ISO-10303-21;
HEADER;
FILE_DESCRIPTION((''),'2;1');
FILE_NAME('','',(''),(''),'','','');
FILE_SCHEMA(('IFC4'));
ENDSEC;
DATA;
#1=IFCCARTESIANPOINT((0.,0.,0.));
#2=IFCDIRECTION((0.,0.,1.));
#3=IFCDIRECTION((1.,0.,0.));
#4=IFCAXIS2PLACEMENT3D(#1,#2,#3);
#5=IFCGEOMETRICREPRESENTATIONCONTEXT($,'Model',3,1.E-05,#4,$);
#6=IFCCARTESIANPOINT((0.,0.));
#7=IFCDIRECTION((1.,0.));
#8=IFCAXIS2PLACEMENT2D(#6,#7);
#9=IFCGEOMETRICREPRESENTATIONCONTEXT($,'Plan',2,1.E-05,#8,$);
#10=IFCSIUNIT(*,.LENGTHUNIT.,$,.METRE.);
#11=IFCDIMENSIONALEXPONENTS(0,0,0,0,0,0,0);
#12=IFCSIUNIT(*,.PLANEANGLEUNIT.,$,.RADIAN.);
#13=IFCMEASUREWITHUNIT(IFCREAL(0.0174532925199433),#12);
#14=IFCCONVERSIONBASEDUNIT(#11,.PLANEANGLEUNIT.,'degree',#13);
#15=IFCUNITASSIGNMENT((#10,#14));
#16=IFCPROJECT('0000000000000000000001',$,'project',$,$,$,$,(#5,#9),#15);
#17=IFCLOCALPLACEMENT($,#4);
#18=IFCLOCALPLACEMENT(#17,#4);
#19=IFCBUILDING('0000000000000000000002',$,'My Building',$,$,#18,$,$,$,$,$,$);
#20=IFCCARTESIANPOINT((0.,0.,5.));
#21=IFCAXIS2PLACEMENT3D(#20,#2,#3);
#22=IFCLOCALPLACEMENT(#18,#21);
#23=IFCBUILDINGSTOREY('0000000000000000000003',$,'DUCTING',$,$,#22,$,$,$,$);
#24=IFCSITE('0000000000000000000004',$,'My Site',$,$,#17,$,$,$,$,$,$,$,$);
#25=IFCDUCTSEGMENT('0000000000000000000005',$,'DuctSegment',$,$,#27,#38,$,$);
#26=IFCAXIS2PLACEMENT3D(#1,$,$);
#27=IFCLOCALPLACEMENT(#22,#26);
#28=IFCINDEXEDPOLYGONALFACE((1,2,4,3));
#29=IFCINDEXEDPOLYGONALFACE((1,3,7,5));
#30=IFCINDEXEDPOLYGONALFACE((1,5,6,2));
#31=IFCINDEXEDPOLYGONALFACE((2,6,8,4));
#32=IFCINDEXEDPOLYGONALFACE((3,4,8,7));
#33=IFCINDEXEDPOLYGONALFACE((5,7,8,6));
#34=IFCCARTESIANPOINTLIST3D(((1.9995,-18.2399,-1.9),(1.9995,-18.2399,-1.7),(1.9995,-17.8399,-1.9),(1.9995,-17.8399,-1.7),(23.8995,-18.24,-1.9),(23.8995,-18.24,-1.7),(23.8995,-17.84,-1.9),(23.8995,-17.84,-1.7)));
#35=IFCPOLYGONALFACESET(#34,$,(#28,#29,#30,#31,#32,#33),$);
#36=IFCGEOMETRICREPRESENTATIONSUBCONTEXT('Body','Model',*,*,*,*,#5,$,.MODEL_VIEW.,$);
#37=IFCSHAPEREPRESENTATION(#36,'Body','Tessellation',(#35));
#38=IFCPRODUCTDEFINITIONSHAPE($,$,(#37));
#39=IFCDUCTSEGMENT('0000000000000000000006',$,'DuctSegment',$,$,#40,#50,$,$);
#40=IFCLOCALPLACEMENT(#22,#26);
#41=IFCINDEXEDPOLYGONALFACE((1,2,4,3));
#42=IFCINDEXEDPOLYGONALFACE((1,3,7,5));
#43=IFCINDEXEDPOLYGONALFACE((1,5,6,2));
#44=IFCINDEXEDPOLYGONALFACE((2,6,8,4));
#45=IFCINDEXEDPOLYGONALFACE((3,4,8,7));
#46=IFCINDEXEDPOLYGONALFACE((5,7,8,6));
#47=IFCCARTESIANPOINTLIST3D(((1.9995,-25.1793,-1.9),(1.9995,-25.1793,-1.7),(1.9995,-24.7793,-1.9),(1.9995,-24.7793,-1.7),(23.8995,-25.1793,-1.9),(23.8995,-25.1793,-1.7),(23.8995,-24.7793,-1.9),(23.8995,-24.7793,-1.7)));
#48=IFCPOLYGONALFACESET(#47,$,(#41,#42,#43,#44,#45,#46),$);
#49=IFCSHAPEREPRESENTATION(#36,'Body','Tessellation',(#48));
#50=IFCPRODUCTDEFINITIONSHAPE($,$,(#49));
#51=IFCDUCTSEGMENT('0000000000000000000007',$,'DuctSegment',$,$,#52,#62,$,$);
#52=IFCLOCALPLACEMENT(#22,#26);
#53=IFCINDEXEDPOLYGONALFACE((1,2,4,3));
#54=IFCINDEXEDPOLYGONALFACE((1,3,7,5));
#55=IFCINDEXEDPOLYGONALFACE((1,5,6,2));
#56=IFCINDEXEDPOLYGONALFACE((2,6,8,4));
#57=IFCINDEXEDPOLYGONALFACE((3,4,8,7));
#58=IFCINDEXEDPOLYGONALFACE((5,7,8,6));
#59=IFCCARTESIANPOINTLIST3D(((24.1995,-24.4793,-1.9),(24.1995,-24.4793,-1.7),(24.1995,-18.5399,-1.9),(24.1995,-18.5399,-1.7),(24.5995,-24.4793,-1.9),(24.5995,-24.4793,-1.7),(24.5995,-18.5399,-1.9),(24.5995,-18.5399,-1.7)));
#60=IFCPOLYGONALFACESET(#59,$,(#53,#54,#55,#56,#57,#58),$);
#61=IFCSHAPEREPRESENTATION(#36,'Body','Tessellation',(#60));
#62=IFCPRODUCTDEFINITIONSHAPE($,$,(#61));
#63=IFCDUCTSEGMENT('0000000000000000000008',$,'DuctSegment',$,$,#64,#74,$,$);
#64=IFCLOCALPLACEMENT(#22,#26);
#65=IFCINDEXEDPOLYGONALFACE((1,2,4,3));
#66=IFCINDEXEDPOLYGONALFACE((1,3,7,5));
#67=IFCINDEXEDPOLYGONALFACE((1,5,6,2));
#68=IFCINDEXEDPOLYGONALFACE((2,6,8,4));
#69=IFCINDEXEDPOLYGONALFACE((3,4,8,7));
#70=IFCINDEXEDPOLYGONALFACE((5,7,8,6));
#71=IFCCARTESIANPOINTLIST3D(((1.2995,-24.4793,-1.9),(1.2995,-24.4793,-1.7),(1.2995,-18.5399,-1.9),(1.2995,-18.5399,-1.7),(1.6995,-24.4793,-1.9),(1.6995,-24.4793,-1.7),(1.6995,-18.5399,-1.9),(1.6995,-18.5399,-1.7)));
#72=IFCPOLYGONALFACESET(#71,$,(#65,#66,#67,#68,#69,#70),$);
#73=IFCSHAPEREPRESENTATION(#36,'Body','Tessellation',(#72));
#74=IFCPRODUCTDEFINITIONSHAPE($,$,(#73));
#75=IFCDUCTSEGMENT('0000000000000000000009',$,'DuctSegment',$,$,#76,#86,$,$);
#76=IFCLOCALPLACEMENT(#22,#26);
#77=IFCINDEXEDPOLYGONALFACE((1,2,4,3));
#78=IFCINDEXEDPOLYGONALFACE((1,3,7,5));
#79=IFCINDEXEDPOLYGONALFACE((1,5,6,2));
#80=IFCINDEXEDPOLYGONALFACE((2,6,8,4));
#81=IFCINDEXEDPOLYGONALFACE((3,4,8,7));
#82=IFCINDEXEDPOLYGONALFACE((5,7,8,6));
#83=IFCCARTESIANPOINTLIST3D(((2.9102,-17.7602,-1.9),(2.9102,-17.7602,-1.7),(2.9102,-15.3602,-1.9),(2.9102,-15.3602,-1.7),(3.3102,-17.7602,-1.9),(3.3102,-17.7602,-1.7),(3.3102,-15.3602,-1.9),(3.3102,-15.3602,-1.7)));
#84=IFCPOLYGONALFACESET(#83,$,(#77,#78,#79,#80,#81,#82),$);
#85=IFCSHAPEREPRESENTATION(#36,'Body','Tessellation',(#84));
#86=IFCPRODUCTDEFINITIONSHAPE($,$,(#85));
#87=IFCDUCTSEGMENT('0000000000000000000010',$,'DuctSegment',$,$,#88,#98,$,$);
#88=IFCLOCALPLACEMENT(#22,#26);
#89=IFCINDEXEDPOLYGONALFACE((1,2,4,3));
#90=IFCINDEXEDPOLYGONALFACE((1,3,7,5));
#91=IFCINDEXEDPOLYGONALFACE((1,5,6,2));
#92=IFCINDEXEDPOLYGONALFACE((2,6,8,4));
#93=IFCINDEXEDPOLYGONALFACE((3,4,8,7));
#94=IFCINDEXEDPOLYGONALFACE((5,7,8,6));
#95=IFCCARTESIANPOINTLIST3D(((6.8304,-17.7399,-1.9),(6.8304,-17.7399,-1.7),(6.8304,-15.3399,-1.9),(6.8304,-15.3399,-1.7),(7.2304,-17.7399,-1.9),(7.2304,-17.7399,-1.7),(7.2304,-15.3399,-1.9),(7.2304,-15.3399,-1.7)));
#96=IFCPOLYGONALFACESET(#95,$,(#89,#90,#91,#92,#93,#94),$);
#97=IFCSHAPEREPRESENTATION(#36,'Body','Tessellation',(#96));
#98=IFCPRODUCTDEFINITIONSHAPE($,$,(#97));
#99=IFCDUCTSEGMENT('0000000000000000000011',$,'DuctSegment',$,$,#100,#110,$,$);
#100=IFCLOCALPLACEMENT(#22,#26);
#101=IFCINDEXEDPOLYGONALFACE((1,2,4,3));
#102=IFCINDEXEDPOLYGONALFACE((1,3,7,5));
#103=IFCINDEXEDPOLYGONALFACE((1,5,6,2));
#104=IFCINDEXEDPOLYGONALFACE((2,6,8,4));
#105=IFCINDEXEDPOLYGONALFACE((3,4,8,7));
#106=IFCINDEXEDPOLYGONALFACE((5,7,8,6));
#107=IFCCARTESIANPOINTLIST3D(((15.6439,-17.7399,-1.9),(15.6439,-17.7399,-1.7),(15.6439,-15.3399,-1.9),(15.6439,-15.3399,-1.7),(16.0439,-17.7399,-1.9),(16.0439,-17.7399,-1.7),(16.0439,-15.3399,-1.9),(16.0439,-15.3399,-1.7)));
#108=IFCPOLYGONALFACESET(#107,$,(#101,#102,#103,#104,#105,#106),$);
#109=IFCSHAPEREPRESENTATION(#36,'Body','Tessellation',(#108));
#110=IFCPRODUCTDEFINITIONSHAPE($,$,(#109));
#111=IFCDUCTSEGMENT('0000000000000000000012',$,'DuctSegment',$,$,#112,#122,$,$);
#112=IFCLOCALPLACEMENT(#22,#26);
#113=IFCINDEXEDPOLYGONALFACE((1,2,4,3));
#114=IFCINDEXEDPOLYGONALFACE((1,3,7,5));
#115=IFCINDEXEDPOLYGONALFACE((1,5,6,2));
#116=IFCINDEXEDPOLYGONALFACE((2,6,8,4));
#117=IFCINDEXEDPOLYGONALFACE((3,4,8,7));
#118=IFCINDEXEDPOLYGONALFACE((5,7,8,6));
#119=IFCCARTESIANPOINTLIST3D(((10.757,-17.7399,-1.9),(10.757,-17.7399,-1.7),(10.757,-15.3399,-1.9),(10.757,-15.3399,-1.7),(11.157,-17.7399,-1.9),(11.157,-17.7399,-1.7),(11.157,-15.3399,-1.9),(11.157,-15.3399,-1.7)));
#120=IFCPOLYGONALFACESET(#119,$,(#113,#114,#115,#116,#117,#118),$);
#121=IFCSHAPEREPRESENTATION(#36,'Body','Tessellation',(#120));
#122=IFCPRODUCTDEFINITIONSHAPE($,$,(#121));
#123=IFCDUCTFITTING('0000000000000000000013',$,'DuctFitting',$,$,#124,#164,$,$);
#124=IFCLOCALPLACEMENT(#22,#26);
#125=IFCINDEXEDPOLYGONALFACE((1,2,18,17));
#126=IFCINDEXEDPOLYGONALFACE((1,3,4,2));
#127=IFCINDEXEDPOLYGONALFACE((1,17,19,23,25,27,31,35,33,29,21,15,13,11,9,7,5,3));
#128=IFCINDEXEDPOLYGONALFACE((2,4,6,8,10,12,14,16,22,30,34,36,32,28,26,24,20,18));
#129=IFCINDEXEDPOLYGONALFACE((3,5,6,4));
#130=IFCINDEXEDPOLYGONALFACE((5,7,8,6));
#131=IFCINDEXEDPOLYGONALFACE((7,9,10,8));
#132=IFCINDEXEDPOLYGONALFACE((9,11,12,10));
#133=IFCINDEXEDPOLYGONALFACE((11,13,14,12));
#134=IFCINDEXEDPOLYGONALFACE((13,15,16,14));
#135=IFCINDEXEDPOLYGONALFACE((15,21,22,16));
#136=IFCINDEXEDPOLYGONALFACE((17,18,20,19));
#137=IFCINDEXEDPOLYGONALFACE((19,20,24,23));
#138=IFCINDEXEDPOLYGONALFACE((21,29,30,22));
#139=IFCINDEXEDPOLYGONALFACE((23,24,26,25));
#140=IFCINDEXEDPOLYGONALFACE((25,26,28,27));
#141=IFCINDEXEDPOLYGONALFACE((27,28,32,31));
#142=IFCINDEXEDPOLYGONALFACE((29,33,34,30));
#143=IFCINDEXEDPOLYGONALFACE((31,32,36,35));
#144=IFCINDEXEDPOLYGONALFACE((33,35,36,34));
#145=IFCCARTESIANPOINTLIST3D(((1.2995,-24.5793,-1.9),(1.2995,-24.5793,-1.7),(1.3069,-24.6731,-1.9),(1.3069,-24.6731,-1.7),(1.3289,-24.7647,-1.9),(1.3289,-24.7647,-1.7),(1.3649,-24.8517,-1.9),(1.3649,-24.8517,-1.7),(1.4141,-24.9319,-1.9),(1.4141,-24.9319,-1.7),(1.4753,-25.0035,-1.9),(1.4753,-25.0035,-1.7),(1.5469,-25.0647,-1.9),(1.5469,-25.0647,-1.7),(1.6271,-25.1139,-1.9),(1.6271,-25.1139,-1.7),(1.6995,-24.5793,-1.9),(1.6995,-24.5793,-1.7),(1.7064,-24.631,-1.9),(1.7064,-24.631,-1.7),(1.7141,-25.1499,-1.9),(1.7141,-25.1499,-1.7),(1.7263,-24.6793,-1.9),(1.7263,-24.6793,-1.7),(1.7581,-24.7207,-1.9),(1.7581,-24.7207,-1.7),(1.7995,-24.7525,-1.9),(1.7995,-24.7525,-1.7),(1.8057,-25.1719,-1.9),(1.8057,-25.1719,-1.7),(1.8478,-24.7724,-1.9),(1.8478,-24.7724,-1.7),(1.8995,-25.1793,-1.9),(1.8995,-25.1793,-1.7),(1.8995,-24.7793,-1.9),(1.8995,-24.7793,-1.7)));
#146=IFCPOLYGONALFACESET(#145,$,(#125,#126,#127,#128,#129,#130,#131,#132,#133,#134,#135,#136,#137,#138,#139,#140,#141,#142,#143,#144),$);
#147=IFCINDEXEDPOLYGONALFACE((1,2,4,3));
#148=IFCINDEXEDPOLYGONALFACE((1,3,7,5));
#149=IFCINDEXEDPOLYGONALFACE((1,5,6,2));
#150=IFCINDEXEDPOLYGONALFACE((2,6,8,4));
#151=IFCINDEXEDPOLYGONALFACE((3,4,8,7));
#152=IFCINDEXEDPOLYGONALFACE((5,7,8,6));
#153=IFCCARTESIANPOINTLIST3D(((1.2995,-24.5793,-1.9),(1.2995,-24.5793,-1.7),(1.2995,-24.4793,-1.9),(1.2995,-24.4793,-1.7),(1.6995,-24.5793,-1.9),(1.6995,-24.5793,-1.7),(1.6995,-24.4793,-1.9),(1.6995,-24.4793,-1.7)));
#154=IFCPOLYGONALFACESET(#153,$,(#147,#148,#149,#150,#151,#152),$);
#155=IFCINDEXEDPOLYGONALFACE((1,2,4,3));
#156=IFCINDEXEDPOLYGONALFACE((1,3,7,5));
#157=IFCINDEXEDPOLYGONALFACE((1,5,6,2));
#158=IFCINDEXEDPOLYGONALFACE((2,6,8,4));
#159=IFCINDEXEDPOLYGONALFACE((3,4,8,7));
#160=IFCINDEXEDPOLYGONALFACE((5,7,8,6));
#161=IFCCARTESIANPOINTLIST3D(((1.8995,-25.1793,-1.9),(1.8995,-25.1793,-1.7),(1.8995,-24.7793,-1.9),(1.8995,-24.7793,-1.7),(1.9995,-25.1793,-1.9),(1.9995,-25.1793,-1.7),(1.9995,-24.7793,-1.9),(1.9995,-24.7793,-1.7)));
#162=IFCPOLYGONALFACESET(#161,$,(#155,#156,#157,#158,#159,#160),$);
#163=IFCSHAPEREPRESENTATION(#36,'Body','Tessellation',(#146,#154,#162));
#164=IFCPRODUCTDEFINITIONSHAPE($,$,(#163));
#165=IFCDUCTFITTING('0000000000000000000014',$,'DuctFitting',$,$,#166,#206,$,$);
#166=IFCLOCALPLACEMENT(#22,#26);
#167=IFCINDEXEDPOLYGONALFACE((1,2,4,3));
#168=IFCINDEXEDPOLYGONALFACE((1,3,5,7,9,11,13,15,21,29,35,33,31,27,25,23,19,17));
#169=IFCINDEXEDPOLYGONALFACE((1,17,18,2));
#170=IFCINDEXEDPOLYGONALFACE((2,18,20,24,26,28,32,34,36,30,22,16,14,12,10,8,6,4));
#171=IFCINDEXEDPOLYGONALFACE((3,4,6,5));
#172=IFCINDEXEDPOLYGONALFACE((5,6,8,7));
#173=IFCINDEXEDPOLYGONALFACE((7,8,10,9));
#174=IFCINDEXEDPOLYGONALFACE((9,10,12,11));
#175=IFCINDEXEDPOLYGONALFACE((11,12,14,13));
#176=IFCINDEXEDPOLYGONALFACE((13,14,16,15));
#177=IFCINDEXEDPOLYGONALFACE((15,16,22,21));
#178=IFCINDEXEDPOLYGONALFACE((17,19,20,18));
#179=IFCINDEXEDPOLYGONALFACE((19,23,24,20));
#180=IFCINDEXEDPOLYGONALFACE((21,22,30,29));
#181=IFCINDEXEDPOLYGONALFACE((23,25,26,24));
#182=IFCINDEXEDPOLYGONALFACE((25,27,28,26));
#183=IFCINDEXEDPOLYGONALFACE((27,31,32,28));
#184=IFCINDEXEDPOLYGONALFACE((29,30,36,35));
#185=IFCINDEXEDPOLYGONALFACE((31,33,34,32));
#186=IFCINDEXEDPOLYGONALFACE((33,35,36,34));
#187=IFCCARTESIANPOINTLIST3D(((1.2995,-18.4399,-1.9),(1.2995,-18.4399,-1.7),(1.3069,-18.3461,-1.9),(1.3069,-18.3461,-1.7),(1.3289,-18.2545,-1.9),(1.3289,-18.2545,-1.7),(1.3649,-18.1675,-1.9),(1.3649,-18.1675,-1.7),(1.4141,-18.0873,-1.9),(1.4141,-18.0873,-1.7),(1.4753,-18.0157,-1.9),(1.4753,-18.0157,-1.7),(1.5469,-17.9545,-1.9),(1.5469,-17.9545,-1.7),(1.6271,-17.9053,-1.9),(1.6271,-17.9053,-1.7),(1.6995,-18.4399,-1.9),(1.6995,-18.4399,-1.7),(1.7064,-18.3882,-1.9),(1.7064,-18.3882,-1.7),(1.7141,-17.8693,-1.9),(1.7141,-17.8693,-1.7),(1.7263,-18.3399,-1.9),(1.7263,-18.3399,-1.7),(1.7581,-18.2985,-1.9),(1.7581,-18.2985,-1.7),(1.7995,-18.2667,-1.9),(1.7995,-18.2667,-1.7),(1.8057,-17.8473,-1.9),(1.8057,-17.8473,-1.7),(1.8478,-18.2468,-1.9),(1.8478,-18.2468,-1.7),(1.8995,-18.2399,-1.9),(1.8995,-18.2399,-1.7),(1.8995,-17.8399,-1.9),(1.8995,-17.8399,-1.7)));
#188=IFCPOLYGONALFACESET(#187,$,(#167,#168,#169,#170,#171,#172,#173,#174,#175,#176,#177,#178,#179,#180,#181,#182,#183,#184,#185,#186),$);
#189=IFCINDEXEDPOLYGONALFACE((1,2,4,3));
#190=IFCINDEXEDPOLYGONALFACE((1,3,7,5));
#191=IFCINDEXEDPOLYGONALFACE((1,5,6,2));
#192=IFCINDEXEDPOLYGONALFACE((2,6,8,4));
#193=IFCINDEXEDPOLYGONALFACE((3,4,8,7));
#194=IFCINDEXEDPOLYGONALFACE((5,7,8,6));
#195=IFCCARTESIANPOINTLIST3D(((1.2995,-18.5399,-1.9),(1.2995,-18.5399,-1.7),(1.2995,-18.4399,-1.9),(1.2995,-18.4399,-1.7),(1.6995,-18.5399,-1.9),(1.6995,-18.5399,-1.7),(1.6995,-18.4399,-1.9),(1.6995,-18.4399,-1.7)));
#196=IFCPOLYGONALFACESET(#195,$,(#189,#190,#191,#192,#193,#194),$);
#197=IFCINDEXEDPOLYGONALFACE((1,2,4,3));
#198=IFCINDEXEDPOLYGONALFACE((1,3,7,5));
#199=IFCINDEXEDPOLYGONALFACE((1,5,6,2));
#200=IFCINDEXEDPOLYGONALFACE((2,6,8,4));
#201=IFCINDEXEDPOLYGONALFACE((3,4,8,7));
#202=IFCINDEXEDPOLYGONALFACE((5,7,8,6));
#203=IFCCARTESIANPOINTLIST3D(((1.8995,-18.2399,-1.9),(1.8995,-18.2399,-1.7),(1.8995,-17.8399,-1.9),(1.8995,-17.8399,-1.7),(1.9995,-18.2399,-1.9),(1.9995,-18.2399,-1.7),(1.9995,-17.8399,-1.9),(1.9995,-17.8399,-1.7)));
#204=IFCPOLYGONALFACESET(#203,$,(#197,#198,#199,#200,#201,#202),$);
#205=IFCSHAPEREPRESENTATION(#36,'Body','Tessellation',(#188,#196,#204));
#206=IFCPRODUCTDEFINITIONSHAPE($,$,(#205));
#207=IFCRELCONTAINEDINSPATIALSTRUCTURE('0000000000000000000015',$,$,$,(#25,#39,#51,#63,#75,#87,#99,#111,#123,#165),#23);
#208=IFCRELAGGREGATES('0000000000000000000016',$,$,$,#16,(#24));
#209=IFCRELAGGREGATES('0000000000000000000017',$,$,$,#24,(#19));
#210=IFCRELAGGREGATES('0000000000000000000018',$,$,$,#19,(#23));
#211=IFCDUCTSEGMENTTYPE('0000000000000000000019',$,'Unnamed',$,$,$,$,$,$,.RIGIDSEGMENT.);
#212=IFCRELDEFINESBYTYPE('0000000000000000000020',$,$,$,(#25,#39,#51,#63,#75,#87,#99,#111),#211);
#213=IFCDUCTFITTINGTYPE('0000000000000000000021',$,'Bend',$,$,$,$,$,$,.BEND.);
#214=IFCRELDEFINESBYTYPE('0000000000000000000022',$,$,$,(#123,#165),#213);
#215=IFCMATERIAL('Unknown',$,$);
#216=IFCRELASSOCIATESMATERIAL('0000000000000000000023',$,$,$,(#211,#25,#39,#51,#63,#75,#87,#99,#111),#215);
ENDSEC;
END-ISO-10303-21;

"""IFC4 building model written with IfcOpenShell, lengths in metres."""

from ifc_helpers import new_model, entity, si_unit, converted_unit, frame, origin_with_axes, origin_2d_with_axis, place, context, subcontext, project, spatial, line, arc, indexed_curve, rectangle, outline, extrude, source, transform, mapped, material, material_profile, profile_set, profile_usage, type_object, type_shapes, element, save


model = new_model("IFC4")

# Units and contexts
model_context = context("Model", 3, precision=1e-05, world=origin_with_axes())
plan_context = context("Plan", 2, precision=1e-05, world=origin_2d_with_axis())
body_context = subcontext(model_context, "Body", "Model", "MODEL_VIEW")
ifc_project = project(units=[si_unit("LENGTHUNIT", "METRE"), converted_unit("PLANEANGLEUNIT", "degree", entity("IfcReal", 0.0174532925199433), si_unit("PLANEANGLEUNIT", "RADIAN"), dimensions=[0, 0, 0, 0, 0, 0, 0])], contexts=[model_context, plan_context])

# Site, building, storey
site_placement = place(None, origin_with_axes())
site = spatial("IfcSite", under=ifc_project, at=site_placement, Name="My Site")
building_placement = place(site_placement, origin_with_axes())
building = spatial("IfcBuilding", under=site, at=building_placement, Name="My Building")
storey_placement = place(building_placement, frame((0.0, 0.0, 5.0), z_axis=(0.0, 0.0, 1.0), x_axis=(1.0, 0.0, 0.0)))
storey = spatial("IfcBuildingStorey", under=building, at=storey_placement, Name="DUCTING")

# Duct segments
ifc_material = material(Name="Unknown")
ifc_material_profile = material_profile(ifc_material, rectangle(XDim=0.4, YDim=0.2))
ifc_profile_set = profile_set([ifc_material_profile])
ifc_profile_usage_1 = profile_usage(ifc_profile_set, cardinal=5)
duct_segment_type = type_object("IfcDuctSegmentType", Name="Unnamed", PredefinedType="RIGIDSEGMENT", material=ifc_profile_set)
duct_segment_1_placement = place(storey_placement, frame((1.9995, -18.0399, -1.8), z_axis=(1.0, -0.000001, 0.000001), x_axis=(0.000001, 1.0, 0.0)))
element("IfcDuctSegment", 1, at=duct_segment_1_placement, inside=storey, type_object=duct_segment_type, material=ifc_profile_usage_1, Name="DuctSegment", context=body_context, shape_type="SweptSolid", body=[
    extrude(rectangle(XDim=0.4, YDim=0.2), origin_with_axes(), (0.0, 0.0, 1.0), 21.9),
])
ifc_profile_usage_2 = profile_usage(ifc_profile_set, cardinal=5)
duct_segment_2_placement = place(storey_placement, frame((1.9995, -24.9793, -1.8), z_axis=(1.0, -0.000001, 0.000001), x_axis=(0.000001, 1.0, 0.0)))
element("IfcDuctSegment", 2, at=duct_segment_2_placement, inside=storey, type_object=duct_segment_type, material=ifc_profile_usage_2, Name="DuctSegment", context=body_context, shape_type="SweptSolid", body=[
    extrude(rectangle(XDim=0.4, YDim=0.2), origin_with_axes(), (0.0, 0.0, 1.0), 21.9),
])
ifc_profile_usage_3 = profile_usage(ifc_profile_set, cardinal=5)
duct_segment_3_placement = place(storey_placement, frame((24.3995, -18.5399, -1.8), z_axis=(0.0, -1.0, 0.0), x_axis=(1.0, 0.0, 0.0)))
element("IfcDuctSegment", 3, at=duct_segment_3_placement, inside=storey, type_object=duct_segment_type, material=ifc_profile_usage_3, Name="DuctSegment", context=body_context, shape_type="SweptSolid", body=[
    extrude(rectangle(XDim=0.4, YDim=0.2), origin_with_axes(), (0.0, 0.0, 1.0), 5.9393),
])
ifc_profile_usage_4 = profile_usage(ifc_profile_set, cardinal=5)
duct_segment_4_placement = place(storey_placement, frame((1.4995, -18.5399, -1.8), z_axis=(0.0, -1.0, 0.0), x_axis=(1.0, 0.0, 0.0)))
element("IfcDuctSegment", 4, at=duct_segment_4_placement, inside=storey, type_object=duct_segment_type, material=ifc_profile_usage_4, Name="DuctSegment", context=body_context, shape_type="SweptSolid", body=[
    extrude(rectangle(XDim=0.4, YDim=0.2), origin_with_axes(), (0.0, 0.0, 1.0), 5.9393),
])
ifc_profile_usage_5 = profile_usage(ifc_profile_set, cardinal=5)
duct_segment_5_placement = place(storey_placement, frame((3.1102, -17.7602, -1.8), z_axis=(0.0, 1.0, 0.0), x_axis=(-1.0, 0.0, 0.0)))
element("IfcDuctSegment", 5, at=duct_segment_5_placement, inside=storey, type_object=duct_segment_type, material=ifc_profile_usage_5, Name="DuctSegment", context=body_context, shape_type="SweptSolid", body=[
    extrude(rectangle(XDim=0.4, YDim=0.2), origin_with_axes(), (0.0, 0.0, 1.0), 2.4),
])
ifc_profile_usage_6 = profile_usage(ifc_profile_set, cardinal=5)
duct_segment_6_placement = place(storey_placement, frame((7.0304, -17.7399, -1.8), z_axis=(0.0, 1.0, -0.000001), x_axis=(-1.0, 0.0, 0.0)))
element("IfcDuctSegment", 6, at=duct_segment_6_placement, inside=storey, type_object=duct_segment_type, material=ifc_profile_usage_6, Name="DuctSegment", context=body_context, shape_type="SweptSolid", body=[
    extrude(rectangle(XDim=0.4, YDim=0.2), origin_with_axes(), (0.0, 0.0, 1.0), 2.4),
])
ifc_profile_usage_7 = profile_usage(ifc_profile_set, cardinal=5)
duct_segment_7_placement = place(storey_placement, frame((15.8439, -17.7399, -1.8), z_axis=(0.0, 1.0, -0.000004), x_axis=(-1.0, 0.0, 0.0)))
element("IfcDuctSegment", 7, at=duct_segment_7_placement, inside=storey, type_object=duct_segment_type, material=ifc_profile_usage_7, Name="DuctSegment", context=body_context, shape_type="SweptSolid", body=[
    extrude(rectangle(XDim=0.4, YDim=0.2), origin_with_axes(), (0.0, 0.0, 1.0), 2.4),
])
ifc_profile_usage_8 = profile_usage(ifc_profile_set, cardinal=5)
duct_segment_8_placement = place(storey_placement, frame((10.957, -17.7399, -1.8), z_axis=(0.0, 1.0, -0.000001), x_axis=(-1.0, 0.0, 0.0)))
element("IfcDuctSegment", 8, at=duct_segment_8_placement, inside=storey, type_object=duct_segment_type, material=ifc_profile_usage_8, Name="DuctSegment", context=body_context, shape_type="SweptSolid", body=[
    extrude(rectangle(XDim=0.4, YDim=0.2), origin_with_axes(), (0.0, 0.0, 1.0), 2.4),
])

# Duct fittings
duct_fitting_type = type_object("IfcDuctFittingType", Name="Bend", PredefinedType="BEND")
shared_shape = source(origin_with_axes(), body_context, "Body", "SweptSolid", [
    extrude(outline(indexed_curve([(0.2, 0.0), (0.2586, 0.1414), (0.4, 0.2), (0.4, 0.6), (-0.0243, 0.4243), (-0.2, 0.0)], segments=[arc(1, 2, 3), line(3, 4), arc(4, 5, 6), line(6, 1)])), frame((0.0, -0.1, 0.1), z_axis=(0.0, -1.0, 0.0), x_axis=(1.0, 0.0, 0.0)), (0.0, 0.0, -1.0), 0.2),
    extrude(rectangle(XDim=0.4, YDim=0.2), origin_with_axes(), (0.0, 0.0, 1.0), 0.1),
    extrude(rectangle(XDim=0.4, YDim=0.2), frame((0.4, 0.0, 0.5), z_axis=(1.0, 0.0, 0.000001), x_axis=(-0.000001, 0.0, 1.0)), (0.0, 0.0, 1.0), 0.1),
])
type_shapes(duct_fitting_type, [shared_shape])
for number, where, z_axis, x_axis, name in (
    (9, (1.4995, -24.4793, -1.8), (0.0, -1.0, 0.0), (1.0, 0.0, 0.0), "DuctFitting"),
    (10, (1.4995, -18.5399, -1.8), (0.0, 1.0, 0.0), (1.0, 0.0, 0.0), "DuctFitting"),
):
    element("IfcDuctFitting", number, at=place(storey_placement, frame(where, z_axis=z_axis, x_axis=x_axis)), inside=storey, type_object=duct_fitting_type, Name=name, context=body_context, shape_type="MappedRepresentation", body=[
        mapped(shared_shape, transform((0.0, 0.0, 0.0), x_axis=(1.0, 0.0, 0.0), y_axis=(0.0, 1.0, 0.0), z_axis=(0.0, 0.0, 1.0), scale=1.0)),
    ])

save(model, "model.ifc")
